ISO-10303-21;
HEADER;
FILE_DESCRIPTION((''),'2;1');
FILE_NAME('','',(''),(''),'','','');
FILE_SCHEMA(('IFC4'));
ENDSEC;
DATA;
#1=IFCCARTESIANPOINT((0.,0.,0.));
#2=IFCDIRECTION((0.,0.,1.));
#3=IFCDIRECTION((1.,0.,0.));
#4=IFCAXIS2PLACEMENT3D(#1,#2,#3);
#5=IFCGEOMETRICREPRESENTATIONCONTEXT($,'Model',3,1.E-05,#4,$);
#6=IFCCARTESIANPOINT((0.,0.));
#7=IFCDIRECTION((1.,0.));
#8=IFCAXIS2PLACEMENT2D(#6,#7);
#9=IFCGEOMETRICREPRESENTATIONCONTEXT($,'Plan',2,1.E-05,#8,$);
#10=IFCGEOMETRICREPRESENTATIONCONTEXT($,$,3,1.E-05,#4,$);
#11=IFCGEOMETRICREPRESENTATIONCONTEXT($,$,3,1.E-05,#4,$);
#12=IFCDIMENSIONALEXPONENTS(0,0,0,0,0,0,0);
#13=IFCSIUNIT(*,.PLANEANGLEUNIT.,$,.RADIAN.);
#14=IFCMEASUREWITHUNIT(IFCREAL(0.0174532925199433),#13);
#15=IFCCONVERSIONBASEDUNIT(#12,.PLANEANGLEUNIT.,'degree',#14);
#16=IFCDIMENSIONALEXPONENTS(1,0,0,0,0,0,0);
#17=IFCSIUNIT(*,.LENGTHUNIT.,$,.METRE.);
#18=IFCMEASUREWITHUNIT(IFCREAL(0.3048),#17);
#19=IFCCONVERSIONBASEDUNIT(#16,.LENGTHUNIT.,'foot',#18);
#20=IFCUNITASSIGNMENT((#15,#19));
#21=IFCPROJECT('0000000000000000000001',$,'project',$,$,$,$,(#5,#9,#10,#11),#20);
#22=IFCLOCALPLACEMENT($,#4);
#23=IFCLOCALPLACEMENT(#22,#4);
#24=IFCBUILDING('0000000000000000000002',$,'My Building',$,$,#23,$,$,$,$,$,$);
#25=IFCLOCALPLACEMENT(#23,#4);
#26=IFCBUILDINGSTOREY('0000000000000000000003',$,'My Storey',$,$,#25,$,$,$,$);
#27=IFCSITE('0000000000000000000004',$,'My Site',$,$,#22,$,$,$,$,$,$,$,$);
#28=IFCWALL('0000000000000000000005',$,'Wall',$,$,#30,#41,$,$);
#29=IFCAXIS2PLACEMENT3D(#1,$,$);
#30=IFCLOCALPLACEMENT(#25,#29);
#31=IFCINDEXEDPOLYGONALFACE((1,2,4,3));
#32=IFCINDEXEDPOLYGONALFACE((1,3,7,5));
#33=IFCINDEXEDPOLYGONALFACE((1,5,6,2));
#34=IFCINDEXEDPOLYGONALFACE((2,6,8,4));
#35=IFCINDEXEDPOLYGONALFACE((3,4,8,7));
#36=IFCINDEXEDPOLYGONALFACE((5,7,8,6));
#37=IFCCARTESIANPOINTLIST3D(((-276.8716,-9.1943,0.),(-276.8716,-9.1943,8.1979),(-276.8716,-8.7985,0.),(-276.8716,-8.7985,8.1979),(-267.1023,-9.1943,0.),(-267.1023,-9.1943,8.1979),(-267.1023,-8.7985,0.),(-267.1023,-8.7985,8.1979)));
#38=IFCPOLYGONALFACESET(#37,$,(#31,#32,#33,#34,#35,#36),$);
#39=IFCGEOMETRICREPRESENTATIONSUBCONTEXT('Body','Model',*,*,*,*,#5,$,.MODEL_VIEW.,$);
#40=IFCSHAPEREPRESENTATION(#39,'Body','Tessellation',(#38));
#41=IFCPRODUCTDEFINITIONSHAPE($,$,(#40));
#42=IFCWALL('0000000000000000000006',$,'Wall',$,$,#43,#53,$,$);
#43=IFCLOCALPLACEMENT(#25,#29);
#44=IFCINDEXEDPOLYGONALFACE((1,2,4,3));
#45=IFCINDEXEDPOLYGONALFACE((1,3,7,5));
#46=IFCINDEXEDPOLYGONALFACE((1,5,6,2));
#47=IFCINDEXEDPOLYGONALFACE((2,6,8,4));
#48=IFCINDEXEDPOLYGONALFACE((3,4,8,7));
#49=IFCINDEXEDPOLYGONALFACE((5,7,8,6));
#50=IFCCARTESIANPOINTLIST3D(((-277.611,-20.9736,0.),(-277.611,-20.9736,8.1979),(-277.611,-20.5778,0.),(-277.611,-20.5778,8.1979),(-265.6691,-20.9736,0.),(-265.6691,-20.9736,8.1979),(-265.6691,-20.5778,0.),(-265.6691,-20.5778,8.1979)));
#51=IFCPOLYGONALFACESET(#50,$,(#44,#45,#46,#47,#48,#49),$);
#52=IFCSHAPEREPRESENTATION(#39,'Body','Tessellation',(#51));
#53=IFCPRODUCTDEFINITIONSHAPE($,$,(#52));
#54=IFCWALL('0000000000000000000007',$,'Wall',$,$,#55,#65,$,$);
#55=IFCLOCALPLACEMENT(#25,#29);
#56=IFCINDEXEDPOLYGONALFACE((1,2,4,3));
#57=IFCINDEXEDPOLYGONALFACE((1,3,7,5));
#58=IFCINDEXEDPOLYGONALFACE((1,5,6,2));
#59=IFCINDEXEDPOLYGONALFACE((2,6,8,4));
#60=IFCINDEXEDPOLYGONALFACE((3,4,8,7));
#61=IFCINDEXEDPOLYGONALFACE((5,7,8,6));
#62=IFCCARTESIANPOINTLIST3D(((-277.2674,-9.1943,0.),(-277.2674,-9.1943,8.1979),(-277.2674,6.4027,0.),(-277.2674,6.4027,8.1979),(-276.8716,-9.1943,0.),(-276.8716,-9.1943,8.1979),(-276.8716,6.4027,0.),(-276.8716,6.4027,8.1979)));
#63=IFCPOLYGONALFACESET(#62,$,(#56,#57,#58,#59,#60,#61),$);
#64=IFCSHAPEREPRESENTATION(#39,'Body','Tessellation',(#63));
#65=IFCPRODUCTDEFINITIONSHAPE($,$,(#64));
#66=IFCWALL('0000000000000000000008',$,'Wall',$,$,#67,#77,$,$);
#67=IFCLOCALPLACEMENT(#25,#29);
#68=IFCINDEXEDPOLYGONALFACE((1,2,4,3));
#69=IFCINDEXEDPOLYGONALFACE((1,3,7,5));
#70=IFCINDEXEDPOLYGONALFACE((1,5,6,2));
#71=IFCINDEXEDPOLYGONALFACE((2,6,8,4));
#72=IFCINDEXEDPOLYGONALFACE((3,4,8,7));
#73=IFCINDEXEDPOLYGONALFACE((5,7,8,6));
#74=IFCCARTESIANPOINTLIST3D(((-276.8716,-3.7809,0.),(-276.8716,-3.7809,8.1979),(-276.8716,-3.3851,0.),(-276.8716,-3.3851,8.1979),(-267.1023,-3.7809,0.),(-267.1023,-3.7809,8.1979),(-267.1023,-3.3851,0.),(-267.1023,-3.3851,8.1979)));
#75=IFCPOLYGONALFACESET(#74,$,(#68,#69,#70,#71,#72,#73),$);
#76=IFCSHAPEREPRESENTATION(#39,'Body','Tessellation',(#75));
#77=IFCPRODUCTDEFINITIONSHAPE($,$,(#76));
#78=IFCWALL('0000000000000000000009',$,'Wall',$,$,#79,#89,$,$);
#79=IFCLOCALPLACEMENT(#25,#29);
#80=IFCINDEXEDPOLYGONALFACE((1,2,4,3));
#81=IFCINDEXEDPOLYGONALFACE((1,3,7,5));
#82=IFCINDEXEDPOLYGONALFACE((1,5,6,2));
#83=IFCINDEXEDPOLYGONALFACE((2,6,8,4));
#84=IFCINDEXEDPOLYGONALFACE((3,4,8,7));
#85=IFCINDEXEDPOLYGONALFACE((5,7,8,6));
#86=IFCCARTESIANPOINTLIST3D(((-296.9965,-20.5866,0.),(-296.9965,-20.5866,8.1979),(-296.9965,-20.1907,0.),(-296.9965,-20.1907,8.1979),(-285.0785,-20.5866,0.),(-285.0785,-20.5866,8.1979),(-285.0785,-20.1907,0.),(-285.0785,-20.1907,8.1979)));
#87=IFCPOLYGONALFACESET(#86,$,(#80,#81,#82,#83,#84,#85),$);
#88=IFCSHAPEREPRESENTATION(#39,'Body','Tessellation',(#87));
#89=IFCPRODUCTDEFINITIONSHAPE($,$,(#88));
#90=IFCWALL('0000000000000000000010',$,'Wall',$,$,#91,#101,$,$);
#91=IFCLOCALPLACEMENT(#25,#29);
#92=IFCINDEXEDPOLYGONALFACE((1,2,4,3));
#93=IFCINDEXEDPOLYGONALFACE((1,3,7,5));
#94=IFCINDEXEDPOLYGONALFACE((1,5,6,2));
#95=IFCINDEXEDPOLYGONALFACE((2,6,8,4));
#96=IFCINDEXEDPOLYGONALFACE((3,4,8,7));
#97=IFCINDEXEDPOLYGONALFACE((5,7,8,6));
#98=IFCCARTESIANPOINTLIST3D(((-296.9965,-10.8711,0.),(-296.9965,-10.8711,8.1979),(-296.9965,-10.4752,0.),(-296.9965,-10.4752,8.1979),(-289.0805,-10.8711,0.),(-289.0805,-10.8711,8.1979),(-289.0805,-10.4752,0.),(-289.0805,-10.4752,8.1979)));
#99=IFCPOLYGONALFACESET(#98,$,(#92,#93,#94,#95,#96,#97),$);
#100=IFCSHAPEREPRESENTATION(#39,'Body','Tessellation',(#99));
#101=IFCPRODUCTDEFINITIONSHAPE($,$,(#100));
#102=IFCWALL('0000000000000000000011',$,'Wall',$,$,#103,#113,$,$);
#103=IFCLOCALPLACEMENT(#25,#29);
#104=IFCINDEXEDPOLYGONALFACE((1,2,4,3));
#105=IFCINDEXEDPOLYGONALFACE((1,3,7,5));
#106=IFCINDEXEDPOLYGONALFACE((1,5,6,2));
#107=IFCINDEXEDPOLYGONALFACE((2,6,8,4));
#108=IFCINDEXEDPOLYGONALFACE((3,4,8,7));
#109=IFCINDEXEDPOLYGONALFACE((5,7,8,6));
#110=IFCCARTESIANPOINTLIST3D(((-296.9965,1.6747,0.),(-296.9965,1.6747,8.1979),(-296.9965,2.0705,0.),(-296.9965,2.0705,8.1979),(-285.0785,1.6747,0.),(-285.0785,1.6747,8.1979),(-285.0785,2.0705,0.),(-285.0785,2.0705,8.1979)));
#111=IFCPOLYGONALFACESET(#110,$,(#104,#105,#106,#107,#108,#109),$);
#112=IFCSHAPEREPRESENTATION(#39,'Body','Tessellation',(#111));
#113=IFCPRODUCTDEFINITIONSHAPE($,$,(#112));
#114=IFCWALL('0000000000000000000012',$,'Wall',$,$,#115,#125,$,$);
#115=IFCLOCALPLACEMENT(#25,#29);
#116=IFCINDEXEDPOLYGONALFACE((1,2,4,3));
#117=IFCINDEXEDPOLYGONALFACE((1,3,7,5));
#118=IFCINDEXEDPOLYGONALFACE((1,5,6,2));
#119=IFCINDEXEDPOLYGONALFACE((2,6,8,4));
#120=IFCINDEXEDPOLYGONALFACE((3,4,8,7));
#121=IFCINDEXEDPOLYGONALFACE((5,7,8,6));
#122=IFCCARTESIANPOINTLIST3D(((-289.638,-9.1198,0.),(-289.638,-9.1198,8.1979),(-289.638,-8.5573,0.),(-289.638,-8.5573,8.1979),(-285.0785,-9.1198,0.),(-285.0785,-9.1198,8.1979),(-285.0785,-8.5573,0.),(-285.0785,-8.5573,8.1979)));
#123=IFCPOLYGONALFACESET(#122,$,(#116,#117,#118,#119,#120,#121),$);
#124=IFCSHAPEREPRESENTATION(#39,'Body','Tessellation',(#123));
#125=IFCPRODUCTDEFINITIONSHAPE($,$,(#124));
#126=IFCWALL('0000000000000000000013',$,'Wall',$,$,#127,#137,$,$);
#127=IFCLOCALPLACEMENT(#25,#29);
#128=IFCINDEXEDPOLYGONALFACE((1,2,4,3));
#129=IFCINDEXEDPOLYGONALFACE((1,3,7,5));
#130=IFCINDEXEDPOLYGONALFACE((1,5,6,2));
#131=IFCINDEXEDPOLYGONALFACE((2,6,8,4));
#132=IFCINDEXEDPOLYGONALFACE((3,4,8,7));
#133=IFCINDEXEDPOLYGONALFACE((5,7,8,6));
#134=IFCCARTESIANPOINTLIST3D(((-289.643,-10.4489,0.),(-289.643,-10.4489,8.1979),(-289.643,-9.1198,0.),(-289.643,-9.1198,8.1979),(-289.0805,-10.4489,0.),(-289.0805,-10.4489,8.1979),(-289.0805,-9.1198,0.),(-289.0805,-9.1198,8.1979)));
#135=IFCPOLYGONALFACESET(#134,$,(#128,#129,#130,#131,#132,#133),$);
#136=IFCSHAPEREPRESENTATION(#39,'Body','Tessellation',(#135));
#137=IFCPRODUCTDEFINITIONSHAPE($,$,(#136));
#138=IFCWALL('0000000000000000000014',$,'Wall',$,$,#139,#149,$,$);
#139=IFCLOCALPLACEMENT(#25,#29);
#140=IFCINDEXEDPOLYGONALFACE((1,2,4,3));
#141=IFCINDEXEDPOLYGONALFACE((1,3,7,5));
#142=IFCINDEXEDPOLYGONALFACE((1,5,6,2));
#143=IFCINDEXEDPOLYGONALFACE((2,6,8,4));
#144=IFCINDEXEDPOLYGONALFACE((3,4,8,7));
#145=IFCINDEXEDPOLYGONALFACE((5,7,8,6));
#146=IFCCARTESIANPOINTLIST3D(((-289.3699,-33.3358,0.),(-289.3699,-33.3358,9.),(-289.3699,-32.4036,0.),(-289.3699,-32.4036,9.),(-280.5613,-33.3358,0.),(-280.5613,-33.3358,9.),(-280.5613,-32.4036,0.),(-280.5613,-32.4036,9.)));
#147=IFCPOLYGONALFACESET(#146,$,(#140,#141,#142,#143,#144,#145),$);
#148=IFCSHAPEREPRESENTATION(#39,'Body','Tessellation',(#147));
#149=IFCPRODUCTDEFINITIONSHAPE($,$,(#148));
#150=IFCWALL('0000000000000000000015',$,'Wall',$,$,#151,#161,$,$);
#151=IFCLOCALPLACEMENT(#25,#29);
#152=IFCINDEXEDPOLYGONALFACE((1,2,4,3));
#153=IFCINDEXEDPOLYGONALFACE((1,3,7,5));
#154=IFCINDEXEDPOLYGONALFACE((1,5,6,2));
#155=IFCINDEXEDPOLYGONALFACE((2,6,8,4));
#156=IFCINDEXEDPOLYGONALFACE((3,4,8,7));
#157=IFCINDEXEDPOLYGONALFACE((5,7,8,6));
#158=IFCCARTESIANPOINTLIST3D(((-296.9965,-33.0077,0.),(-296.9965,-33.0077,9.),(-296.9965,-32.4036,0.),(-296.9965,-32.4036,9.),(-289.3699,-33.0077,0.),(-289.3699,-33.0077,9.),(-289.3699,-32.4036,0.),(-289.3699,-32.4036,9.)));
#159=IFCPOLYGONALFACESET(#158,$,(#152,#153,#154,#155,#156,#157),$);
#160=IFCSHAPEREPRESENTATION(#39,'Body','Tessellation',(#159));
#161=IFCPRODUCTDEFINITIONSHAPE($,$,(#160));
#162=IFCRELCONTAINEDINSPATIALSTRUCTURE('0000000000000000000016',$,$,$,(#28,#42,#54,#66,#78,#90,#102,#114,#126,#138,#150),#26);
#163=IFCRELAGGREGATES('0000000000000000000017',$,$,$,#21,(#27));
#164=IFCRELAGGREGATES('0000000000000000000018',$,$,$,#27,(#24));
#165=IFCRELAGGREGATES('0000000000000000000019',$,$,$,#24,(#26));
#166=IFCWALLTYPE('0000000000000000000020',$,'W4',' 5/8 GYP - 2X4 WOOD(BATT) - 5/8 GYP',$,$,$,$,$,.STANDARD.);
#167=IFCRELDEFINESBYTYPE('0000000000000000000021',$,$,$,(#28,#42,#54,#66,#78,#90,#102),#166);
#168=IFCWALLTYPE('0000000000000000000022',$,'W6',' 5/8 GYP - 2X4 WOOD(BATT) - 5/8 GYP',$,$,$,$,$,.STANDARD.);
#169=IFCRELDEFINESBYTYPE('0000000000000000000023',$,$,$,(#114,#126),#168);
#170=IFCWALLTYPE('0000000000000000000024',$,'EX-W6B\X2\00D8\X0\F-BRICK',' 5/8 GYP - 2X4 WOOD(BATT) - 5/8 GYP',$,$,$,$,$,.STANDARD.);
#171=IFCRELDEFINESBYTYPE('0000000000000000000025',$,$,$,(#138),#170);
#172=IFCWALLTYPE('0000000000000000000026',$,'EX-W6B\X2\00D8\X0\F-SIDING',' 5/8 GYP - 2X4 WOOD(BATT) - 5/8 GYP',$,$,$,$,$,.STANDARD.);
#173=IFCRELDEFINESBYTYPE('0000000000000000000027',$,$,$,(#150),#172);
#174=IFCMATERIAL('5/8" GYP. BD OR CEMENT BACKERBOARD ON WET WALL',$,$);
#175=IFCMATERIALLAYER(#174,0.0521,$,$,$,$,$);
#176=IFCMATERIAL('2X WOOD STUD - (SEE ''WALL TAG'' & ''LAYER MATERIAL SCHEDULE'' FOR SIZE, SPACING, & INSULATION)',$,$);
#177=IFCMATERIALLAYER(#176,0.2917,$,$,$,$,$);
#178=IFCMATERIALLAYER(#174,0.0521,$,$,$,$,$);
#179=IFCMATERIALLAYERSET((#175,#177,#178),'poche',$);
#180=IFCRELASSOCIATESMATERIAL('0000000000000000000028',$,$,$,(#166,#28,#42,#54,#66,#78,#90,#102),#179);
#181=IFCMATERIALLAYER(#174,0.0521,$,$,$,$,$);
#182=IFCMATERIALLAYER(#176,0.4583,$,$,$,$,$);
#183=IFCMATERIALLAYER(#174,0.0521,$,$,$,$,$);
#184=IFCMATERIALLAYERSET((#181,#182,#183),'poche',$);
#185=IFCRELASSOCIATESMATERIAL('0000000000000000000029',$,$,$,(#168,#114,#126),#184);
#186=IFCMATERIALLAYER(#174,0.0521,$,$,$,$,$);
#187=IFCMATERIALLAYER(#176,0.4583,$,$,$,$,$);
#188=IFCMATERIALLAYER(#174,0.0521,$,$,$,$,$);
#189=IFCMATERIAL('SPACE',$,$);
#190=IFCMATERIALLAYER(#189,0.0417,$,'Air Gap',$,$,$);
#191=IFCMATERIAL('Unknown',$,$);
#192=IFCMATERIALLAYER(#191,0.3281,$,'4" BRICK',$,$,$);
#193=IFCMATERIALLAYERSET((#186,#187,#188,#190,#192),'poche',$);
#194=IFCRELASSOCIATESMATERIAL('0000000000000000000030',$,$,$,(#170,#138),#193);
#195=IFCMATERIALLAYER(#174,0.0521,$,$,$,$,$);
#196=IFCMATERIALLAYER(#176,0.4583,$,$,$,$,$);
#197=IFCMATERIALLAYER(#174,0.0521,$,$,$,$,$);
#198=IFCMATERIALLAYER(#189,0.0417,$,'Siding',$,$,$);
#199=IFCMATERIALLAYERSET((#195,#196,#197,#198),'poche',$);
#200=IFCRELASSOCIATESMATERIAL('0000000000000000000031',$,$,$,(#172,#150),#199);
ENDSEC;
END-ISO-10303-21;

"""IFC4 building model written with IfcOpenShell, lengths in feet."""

from ifc_helpers import new_model, entity, si_unit, converted_unit, frame, origin_with_axes, origin_2d_with_axis, place, context, subcontext, project, spatial, indexed_curve, outline, extrude, material, layer, layer_set, layer_usage, type_object, element, save


model = new_model("IFC4")

# Units and contexts
model_context = context("Model", 3, precision=1e-05, world=origin_with_axes())
plan_context = context("Plan", 2, precision=1e-05, world=origin_2d_with_axis())
context_of_model_1 = context(None, 3, precision=1e-05, world=origin_with_axes())
context_of_model_2 = context(None, 3, precision=1e-05, world=origin_with_axes())
body_context = subcontext(model_context, "Body", "Model", "MODEL_VIEW")
ifc_project = project(units=[converted_unit("PLANEANGLEUNIT", "degree", entity("IfcReal", 0.0174532925199433), si_unit("PLANEANGLEUNIT", "RADIAN"), dimensions=[0, 0, 0, 0, 0, 0, 0]), converted_unit("LENGTHUNIT", "foot", entity("IfcReal", 0.3048), si_unit("LENGTHUNIT", "METRE"), dimensions=[1, 0, 0, 0, 0, 0, 0])], contexts=[model_context, plan_context, context_of_model_1, context_of_model_2])

# Site, building, storey
site_placement = place(None, origin_with_axes())
site = spatial("IfcSite", under=ifc_project, at=site_placement, Name="My Site")
building_placement = place(site_placement, origin_with_axes())
building = spatial("IfcBuilding", under=site, at=building_placement, Name="My Building")
storey_placement = place(building_placement, origin_with_axes())
storey = spatial("IfcBuildingStorey", under=building, at=storey_placement, Name="My Storey")

# Walls
ifc_material_1 = material(Name="5/8\" GYP. BD OR CEMENT BACKERBOARD ON WET WALL")
ifc_layer_1 = layer(ifc_material_1, 0.0521)
ifc_material_2 = material(Name="2X WOOD STUD - (SEE 'WALL TAG' & 'LAYER MATERIAL SCHEDULE' FOR SIZE, SPACING, & INSULATION)")
ifc_layer_2 = layer(ifc_material_2, 0.2917)
ifc_layer_3 = layer(ifc_material_1, 0.0521)
ifc_layer_set_1 = layer_set([ifc_layer_1, ifc_layer_2, ifc_layer_3], Name="poche")
ifc_layer_usage_1 = layer_usage(ifc_layer_set_1, "AXIS2", "POSITIVE", 0.0)
wall_type_1 = type_object("IfcWallType", Name="W4", Description=" 5/8 GYP - 2X4 WOOD(BATT) - 5/8 GYP", PredefinedType="STANDARD", material=ifc_layer_set_1)
wall_1_placement = place(storey_placement, frame((-276.8716, -9.1943, 0.0), z_axis=(0.0, 0.0, 1.0), x_axis=(1.0, 0.0, 0.0)))
element("IfcWall", 1, at=wall_1_placement, inside=storey, type_object=wall_type_1, material=ifc_layer_usage_1, Name="Wall", context=body_context, shape_type="SweptSolid", body=[
    extrude(outline(indexed_curve([(0.0, 0.0), (0.0, 0.3958), (9.7693, 0.3958), (9.7693, 0.0), (0.0, 0.0)], self_intersect=False)), origin_with_axes(), (0.0, 0.0, 1.0), 8.1979),
])
ifc_layer_usage_2 = layer_usage(ifc_layer_set_1, "AXIS2", "POSITIVE", 0.0)
wall_2_placement = place(storey_placement, frame((-277.611, -20.9736, 0.0), z_axis=(0.0, 0.0, 1.0), x_axis=(1.0, 0.0, 0.0)))
element("IfcWall", 2, at=wall_2_placement, inside=storey, type_object=wall_type_1, material=ifc_layer_usage_2, Name="Wall", context=body_context, shape_type="SweptSolid", body=[
    extrude(outline(indexed_curve([(0.0, 0.0), (0.0, 0.3958), (11.9419, 0.3958), (11.9419, 0.0), (0.0, 0.0)], self_intersect=False)), origin_with_axes(), (0.0, 0.0, 1.0), 8.1979),
])
ifc_layer_usage_3 = layer_usage(ifc_layer_set_1, "AXIS2", "POSITIVE", 0.0)
wall_3_placement = place(storey_placement, frame((-276.8716, -9.1943, 0.0), z_axis=(0.0, 0.0, 1.0), x_axis=(0.0, 1.0, 0.0)))
element("IfcWall", 3, at=wall_3_placement, inside=storey, type_object=wall_type_1, material=ifc_layer_usage_3, Name="Wall", context=body_context, shape_type="SweptSolid", body=[
    extrude(outline(indexed_curve([(0.0, 0.0), (0.0, 0.3958), (15.597, 0.3958), (15.597, 0.0), (0.0, 0.0)], self_intersect=False)), origin_with_axes(), (0.0, 0.0, 1.0), 8.1979),
])

# Walls
ifc_layer_usage_4 = layer_usage(ifc_layer_set_1, "AXIS2", "POSITIVE", 0.0)
wall_4_placement = place(storey_placement, frame((-276.8716, -3.7809, 0.0), z_axis=(0.0, 0.0, 1.0), x_axis=(1.0, 0.0, 0.0)))
element("IfcWall", 4, at=wall_4_placement, inside=storey, type_object=wall_type_1, material=ifc_layer_usage_4, Name="Wall", context=body_context, shape_type="SweptSolid", body=[
    extrude(outline(indexed_curve([(0.0, 0.0), (0.0, 0.3958), (9.7693, 0.3958), (9.7693, 0.0), (0.0, 0.0)], self_intersect=False)), origin_with_axes(), (0.0, 0.0, 1.0), 8.1979),
])
ifc_layer_usage_5 = layer_usage(ifc_layer_set_1, "AXIS2", "POSITIVE", 0.0)
wall_5_placement = place(storey_placement, frame((-296.9965, -20.5866, 0.0), z_axis=(0.0, 0.0, 1.0), x_axis=(1.0, 0.0, 0.0)))
element("IfcWall", 5, at=wall_5_placement, inside=storey, type_object=wall_type_1, material=ifc_layer_usage_5, Name="Wall", context=body_context, shape_type="SweptSolid", body=[
    extrude(outline(indexed_curve([(0.0, 0.0), (0.0, 0.3958), (11.918, 0.3958), (11.918, 0.0), (0.0, 0.0)], self_intersect=False)), origin_with_axes(), (0.0, 0.0, 1.0), 8.1979),
])
ifc_layer_usage_6 = layer_usage(ifc_layer_set_1, "AXIS2", "POSITIVE", 0.0)
wall_6_placement = place(storey_placement, frame((-296.9965, -10.8711, 0.0), z_axis=(0.0, 0.0, 1.0), x_axis=(1.0, 0.0, 0.0)))
element("IfcWall", 6, at=wall_6_placement, inside=storey, type_object=wall_type_1, material=ifc_layer_usage_6, Name="Wall", context=body_context, shape_type="SweptSolid", body=[
    extrude(outline(indexed_curve([(0.0, 0.0), (0.0, 0.3958), (7.916, 0.3958), (7.916, 0.0), (0.0, 0.0)], self_intersect=False)), origin_with_axes(), (0.0, 0.0, 1.0), 8.1979),
])
ifc_layer_usage_7 = layer_usage(ifc_layer_set_1, "AXIS2", "POSITIVE", 0.0)
wall_7_placement = place(storey_placement, frame((-296.9965, 1.6747, 0.0), z_axis=(0.0, 0.0, 1.0), x_axis=(1.0, 0.0, 0.0)))
element("IfcWall", 7, at=wall_7_placement, inside=storey, type_object=wall_type_1, material=ifc_layer_usage_7, Name="Wall", context=body_context, shape_type="SweptSolid", body=[
    extrude(outline(indexed_curve([(0.0, 0.0), (0.0, 0.3958), (11.918, 0.3958), (11.918, 0.0), (0.0, 0.0)], self_intersect=False)), origin_with_axes(), (0.0, 0.0, 1.0), 8.1979),
])
ifc_layer_4 = layer(ifc_material_1, 0.0521)
ifc_layer_5 = layer(ifc_material_2, 0.4583)
ifc_layer_6 = layer(ifc_material_1, 0.0521)
ifc_layer_set_2 = layer_set([ifc_layer_4, ifc_layer_5, ifc_layer_6], Name="poche")
ifc_layer_usage_8 = layer_usage(ifc_layer_set_2, "AXIS2", "POSITIVE", 0.0)
wall_type_2 = type_object("IfcWallType", Name="W6", Description=" 5/8 GYP - 2X4 WOOD(BATT) - 5/8 GYP", PredefinedType="STANDARD", material=ifc_layer_set_2)
wall_8_placement = place(storey_placement, frame((-289.638, -9.1198, 0.0), z_axis=(0.0, 0.0, 1.0), x_axis=(1.0, 0.0, 0.0)))
element("IfcWall", 8, at=wall_8_placement, inside=storey, type_object=wall_type_2, material=ifc_layer_usage_8, Name="Wall", context=body_context, shape_type="SweptSolid", body=[
    extrude(outline(indexed_curve([(0.0, 0.0), (0.0, 0.5625), (4.5596, 0.5625), (4.5596, 0.0), (0.0, 0.0)], self_intersect=False)), origin_with_axes(), (0.0, 0.0, 1.0), 8.1979),
])
ifc_layer_usage_9 = layer_usage(ifc_layer_set_2, "AXIS2", "POSITIVE", 0.0)
wall_9_placement = place(storey_placement, frame((-289.0805, -10.4489, 0.0), z_axis=(0.0, 0.0, 1.0), x_axis=(0.0, 1.0, 0.0)))
element("IfcWall", 9, at=wall_9_placement, inside=storey, type_object=wall_type_2, material=ifc_layer_usage_9, Name="Wall", context=body_context, shape_type="SweptSolid", body=[
    extrude(outline(indexed_curve([(0.0, 0.0), (0.0, 0.5625), (1.329, 0.5625), (1.329, 0.0), (0.0, 0.0)], self_intersect=False)), origin_with_axes(), (0.0, 0.0, 1.0), 8.1979),
])
ifc_layer_7 = layer(ifc_material_1, 0.0521)
ifc_layer_8 = layer(ifc_material_2, 0.4583)
ifc_layer_9 = layer(ifc_material_1, 0.0521)
ifc_material_3 = material(Name="SPACE")
ifc_layer_10 = layer(ifc_material_3, 0.0417, Name="Air Gap")
ifc_material_4 = material(Name="Unknown")
ifc_layer_11 = layer(ifc_material_4, 0.3281, Name="4\" BRICK")
ifc_layer_set_3 = layer_set([ifc_layer_7, ifc_layer_8, ifc_layer_9, ifc_layer_10, ifc_layer_11], Name="poche")
ifc_layer_usage_10 = layer_usage(ifc_layer_set_3, "AXIS2", "POSITIVE", 0.0)
wall_type_3 = type_object("IfcWallType", Name="EX-W6BØF-BRICK", Description=" 5/8 GYP - 2X4 WOOD(BATT) - 5/8 GYP", PredefinedType="STANDARD", material=ifc_layer_set_3)
wall_10_placement = place(storey_placement, frame((-280.5613, -32.4036, 0.0), z_axis=(0.0, 0.0, 1.0), x_axis=(-1.0, 0.0, 0.0)))
element("IfcWall", 10, at=wall_10_placement, inside=storey, type_object=wall_type_3, material=ifc_layer_usage_10, Name="Wall", context=body_context, shape_type="SweptSolid", body=[
    extrude(outline(indexed_curve([(0.0, 0.0), (0.0, 0.9323), (8.8086, 0.9323), (8.8086, 0.0), (0.0, 0.0)], self_intersect=False)), origin_with_axes(), (0.0, 0.0, 1.0), 9.0),
])
ifc_layer_12 = layer(ifc_material_1, 0.0521)
ifc_layer_13 = layer(ifc_material_2, 0.4583)
ifc_layer_14 = layer(ifc_material_1, 0.0521)
ifc_layer_15 = layer(ifc_material_3, 0.0417, Name="Siding")
ifc_layer_set_4 = layer_set([ifc_layer_12, ifc_layer_13, ifc_layer_14, ifc_layer_15], Name="poche")
ifc_layer_usage_11 = layer_usage(ifc_layer_set_4, "AXIS2", "POSITIVE", 0.0)
wall_type_4 = type_object("IfcWallType", Name="EX-W6BØF-SIDING", Description=" 5/8 GYP - 2X4 WOOD(BATT) - 5/8 GYP", PredefinedType="STANDARD", material=ifc_layer_set_4)
wall_11_placement = place(storey_placement, frame((-289.3699, -32.4036, 0.0), z_axis=(0.0, 0.0, 1.0), x_axis=(-1.0, 0.0, 0.0)))
element("IfcWall", 11, at=wall_11_placement, inside=storey, type_object=wall_type_4, material=ifc_layer_usage_11, Name="Wall", context=body_context, shape_type="SweptSolid", body=[
    extrude(outline(indexed_curve([(0.0, 0.0), (0.0, 0.6042), (7.6266, 0.6042), (7.6266, 0.0), (0.0, 0.0)], self_intersect=False)), origin_with_axes(), (0.0, 0.0, 1.0), 9.0),
])

save(model, "model.ifc")
